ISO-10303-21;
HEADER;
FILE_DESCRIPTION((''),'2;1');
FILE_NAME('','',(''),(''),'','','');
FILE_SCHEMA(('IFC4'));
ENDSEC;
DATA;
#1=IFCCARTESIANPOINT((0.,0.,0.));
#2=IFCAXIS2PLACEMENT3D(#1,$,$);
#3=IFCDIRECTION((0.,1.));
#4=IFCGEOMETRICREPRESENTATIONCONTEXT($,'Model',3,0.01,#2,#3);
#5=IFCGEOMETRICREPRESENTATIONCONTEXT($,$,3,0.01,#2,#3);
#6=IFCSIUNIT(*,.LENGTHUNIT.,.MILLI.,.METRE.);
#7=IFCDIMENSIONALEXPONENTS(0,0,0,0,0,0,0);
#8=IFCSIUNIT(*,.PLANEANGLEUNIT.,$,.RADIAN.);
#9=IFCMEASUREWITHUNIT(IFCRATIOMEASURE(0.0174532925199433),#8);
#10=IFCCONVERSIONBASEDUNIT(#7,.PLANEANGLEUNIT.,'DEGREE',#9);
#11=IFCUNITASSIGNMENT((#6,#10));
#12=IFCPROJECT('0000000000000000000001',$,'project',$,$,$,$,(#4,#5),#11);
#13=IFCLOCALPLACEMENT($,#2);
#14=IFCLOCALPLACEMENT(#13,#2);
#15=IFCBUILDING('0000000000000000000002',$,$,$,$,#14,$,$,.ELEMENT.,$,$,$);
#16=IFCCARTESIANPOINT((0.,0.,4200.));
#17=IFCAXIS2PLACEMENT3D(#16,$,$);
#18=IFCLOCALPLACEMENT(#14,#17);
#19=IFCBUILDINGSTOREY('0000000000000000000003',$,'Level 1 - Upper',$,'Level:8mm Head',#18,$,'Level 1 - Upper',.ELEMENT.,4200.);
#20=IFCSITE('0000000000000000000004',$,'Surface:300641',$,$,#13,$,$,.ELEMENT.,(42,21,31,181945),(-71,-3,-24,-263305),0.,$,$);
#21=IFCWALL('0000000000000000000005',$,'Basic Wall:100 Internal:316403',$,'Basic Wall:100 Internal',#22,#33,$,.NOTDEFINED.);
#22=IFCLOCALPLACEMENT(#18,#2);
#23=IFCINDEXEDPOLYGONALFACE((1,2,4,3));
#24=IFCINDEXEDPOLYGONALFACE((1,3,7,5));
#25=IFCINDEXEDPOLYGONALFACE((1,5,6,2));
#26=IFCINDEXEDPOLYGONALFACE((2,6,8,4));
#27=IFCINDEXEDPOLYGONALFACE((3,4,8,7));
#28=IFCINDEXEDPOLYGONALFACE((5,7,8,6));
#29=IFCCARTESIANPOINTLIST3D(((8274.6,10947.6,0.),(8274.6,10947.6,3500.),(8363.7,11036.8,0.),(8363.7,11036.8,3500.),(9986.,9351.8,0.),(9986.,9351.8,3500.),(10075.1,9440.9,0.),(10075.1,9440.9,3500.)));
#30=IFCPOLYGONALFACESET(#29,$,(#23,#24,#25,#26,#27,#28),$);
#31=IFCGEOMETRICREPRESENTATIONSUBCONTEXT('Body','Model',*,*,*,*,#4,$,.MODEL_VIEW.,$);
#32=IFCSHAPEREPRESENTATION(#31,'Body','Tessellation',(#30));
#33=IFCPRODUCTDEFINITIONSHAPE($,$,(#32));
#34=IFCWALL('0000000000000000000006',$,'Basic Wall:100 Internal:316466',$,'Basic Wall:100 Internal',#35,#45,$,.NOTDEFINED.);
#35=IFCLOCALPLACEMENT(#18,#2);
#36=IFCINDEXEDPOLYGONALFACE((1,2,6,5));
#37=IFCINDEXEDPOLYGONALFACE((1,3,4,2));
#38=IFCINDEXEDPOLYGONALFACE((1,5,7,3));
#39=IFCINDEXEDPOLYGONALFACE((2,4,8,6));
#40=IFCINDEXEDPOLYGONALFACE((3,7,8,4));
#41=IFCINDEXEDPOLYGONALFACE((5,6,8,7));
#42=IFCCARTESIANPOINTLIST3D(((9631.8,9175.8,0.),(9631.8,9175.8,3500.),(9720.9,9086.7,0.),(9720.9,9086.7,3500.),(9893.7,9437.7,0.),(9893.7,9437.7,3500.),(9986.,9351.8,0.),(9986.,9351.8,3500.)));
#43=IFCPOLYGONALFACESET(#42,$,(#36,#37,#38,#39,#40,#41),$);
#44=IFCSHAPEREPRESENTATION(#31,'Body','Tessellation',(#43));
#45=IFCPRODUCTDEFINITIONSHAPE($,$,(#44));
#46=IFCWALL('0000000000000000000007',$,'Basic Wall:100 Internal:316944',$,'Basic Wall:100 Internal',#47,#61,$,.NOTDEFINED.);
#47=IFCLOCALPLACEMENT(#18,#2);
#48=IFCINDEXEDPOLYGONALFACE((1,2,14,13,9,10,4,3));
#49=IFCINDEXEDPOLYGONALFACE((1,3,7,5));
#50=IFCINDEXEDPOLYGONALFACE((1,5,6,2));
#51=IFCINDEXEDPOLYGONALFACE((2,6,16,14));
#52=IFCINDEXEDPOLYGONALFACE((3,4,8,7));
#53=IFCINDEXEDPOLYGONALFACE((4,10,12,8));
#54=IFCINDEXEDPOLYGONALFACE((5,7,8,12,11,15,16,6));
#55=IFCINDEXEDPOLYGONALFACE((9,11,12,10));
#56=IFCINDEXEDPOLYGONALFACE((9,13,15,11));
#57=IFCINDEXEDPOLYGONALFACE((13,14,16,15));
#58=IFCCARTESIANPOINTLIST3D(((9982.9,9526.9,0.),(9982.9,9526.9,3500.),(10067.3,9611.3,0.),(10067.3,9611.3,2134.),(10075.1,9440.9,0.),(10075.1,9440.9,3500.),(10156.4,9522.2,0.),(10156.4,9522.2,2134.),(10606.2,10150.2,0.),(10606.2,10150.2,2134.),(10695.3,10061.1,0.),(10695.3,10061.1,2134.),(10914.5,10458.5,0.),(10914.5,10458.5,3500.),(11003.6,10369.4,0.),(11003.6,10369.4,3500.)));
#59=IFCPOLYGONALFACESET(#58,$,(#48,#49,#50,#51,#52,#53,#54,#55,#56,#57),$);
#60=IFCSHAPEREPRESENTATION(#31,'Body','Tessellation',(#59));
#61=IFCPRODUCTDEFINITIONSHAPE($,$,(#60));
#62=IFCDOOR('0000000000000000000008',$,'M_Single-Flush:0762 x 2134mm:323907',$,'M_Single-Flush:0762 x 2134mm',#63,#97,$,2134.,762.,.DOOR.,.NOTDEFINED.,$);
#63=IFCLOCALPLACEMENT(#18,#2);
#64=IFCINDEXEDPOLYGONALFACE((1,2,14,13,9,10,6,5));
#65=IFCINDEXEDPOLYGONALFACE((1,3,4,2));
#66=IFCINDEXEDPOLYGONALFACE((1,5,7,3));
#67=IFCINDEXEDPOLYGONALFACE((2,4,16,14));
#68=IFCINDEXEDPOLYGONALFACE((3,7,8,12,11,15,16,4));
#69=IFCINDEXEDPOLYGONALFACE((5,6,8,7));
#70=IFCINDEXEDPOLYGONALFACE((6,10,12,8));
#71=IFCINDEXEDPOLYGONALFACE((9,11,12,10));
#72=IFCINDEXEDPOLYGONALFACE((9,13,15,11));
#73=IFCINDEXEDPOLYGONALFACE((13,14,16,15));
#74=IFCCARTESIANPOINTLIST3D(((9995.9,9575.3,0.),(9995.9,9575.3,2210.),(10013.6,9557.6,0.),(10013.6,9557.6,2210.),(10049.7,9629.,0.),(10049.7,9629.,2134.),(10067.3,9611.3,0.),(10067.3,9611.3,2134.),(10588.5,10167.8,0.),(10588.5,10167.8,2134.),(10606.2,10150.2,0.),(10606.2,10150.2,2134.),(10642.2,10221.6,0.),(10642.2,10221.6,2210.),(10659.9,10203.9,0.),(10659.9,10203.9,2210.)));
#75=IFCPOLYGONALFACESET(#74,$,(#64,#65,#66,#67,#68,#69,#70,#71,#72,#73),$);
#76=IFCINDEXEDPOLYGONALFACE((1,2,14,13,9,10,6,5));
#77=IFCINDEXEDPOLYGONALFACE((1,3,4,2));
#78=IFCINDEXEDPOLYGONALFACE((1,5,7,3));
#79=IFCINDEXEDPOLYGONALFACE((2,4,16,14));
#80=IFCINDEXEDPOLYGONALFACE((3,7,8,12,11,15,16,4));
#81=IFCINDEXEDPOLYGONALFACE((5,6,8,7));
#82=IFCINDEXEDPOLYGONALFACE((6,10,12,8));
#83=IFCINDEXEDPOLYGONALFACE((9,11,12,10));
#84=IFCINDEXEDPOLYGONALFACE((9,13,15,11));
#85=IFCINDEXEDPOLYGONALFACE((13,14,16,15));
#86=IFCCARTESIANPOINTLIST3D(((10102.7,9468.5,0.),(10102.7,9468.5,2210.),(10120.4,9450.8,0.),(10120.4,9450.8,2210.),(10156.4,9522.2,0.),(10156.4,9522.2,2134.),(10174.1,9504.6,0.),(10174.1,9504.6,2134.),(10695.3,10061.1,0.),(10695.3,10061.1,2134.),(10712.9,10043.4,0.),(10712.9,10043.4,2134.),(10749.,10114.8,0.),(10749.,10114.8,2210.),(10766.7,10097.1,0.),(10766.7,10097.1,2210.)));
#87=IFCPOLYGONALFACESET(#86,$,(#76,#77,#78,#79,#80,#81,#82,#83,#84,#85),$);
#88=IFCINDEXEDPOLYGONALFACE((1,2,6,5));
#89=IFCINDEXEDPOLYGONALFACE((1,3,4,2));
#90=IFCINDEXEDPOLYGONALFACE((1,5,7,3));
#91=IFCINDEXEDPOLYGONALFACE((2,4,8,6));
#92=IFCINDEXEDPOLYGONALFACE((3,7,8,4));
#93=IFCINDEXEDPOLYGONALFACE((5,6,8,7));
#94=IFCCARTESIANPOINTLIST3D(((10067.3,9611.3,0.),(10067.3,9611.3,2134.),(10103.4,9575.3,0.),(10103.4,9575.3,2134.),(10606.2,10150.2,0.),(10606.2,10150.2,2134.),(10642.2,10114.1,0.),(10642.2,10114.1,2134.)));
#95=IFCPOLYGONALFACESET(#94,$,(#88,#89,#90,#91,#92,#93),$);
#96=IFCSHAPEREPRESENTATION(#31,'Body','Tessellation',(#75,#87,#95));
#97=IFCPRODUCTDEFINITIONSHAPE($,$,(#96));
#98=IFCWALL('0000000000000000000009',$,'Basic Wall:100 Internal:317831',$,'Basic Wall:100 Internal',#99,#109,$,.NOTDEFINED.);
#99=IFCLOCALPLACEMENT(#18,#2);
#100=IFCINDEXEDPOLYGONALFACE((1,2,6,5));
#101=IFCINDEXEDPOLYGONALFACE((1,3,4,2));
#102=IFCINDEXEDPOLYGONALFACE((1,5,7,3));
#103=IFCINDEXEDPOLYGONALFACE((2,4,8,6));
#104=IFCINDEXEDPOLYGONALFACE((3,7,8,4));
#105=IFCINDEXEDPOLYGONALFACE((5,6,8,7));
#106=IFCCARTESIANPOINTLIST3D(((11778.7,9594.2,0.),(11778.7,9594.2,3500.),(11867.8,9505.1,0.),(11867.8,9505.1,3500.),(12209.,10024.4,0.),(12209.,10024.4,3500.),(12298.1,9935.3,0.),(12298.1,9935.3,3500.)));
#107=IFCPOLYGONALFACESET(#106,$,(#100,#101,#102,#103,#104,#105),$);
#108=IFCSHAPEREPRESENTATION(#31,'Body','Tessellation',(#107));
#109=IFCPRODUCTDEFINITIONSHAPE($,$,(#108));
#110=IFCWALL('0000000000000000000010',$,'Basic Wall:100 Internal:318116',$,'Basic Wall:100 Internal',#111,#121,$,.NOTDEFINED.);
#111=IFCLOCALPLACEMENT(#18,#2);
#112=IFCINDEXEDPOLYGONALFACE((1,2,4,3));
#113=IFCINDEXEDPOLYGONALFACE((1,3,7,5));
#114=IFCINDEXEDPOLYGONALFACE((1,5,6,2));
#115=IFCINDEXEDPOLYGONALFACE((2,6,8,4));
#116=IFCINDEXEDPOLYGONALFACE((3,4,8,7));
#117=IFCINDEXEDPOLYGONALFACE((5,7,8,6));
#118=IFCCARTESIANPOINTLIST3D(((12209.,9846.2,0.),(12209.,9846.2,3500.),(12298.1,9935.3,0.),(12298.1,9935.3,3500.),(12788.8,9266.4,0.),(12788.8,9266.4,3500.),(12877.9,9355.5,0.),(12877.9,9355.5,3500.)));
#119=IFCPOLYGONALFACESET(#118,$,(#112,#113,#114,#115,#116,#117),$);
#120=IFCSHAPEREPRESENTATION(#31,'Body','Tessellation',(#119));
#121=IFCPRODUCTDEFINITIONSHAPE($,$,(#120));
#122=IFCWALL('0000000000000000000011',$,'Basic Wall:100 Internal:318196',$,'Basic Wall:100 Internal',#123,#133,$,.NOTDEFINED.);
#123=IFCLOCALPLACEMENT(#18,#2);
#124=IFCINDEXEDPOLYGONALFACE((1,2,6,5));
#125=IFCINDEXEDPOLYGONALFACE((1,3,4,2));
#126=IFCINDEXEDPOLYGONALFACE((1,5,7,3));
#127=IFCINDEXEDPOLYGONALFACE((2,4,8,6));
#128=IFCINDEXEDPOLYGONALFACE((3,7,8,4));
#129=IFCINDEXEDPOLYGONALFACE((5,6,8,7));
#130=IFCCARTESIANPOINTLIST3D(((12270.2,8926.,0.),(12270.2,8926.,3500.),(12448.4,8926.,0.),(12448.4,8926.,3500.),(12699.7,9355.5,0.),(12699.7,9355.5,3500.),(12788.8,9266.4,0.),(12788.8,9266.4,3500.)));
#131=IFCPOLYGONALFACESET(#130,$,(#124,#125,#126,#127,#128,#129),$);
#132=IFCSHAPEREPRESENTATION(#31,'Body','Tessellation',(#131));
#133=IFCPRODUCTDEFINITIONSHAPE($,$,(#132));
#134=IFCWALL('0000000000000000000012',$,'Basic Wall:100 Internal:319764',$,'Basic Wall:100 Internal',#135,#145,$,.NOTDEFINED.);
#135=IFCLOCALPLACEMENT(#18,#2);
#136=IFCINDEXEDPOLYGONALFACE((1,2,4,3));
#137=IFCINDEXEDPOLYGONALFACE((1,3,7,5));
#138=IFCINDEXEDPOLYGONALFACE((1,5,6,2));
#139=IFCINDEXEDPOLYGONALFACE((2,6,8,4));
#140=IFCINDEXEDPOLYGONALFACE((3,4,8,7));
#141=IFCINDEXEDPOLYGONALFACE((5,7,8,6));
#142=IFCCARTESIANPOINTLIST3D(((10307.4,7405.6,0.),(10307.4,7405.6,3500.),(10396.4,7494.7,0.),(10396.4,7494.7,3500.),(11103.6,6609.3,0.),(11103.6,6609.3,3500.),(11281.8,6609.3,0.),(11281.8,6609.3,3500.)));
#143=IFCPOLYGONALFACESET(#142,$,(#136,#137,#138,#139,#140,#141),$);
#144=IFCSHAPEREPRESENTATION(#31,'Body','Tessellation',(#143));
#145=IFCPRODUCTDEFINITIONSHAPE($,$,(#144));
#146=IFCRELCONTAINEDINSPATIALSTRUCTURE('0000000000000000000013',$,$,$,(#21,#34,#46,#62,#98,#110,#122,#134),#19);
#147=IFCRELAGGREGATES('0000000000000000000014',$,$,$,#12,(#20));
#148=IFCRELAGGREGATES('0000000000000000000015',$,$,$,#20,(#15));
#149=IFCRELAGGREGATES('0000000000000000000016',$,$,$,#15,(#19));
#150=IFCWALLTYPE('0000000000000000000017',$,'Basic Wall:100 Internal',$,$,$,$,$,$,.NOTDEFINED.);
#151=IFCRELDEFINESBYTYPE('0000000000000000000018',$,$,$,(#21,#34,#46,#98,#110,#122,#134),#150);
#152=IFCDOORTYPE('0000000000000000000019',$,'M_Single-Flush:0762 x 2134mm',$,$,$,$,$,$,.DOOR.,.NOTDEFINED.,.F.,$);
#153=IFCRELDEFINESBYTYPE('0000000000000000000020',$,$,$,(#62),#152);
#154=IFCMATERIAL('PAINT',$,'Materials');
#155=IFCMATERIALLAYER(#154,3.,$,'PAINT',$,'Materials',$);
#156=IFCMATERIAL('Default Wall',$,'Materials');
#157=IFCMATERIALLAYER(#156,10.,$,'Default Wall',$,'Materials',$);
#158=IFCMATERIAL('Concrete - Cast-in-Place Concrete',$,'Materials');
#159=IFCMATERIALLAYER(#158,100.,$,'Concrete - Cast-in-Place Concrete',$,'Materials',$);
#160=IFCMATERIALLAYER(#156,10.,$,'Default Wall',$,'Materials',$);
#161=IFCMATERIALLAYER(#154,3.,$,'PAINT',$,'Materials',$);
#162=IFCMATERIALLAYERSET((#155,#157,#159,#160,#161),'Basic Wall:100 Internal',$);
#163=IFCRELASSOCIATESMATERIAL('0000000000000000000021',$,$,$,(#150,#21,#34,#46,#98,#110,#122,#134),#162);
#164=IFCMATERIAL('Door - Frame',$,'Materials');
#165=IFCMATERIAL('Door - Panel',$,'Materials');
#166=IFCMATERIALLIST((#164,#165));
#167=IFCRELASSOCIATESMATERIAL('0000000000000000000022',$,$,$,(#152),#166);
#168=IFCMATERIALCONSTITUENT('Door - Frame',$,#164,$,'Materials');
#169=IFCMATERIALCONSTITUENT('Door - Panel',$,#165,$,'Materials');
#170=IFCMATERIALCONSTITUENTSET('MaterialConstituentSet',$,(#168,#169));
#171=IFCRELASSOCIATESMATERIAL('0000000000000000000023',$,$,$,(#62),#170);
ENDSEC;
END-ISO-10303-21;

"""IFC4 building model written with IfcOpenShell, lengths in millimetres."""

from ifc_helpers import new_model, entity, si_unit, converted_unit, direction, frame, frame_2d, origin, place, context, subcontext, project, spatial, polyline, rectangle, outline, extrude, clip, halfspace, source, transform, mapped, material, material_list, layer, layer_set, layer_usage, constituent, constituent_set, type_object, type_shapes, element, fill, save


model = new_model("IFC4")

# Units and contexts
model_context = context("Model", 3, precision=0.01, world=origin(), true_north=direction((0.0, 1.0)))
context_of_model = context(None, 3, precision=0.01, world=origin(), true_north=direction((0.0, 1.0)))
body_context = subcontext(model_context, "Body", "Model", "MODEL_VIEW")
ifc_project = project(units=[si_unit("LENGTHUNIT", "METRE", prefix="MILLI"), converted_unit("PLANEANGLEUNIT", "DEGREE", entity("IfcRatioMeasure", 0.0174532925199433), si_unit("PLANEANGLEUNIT", "RADIAN"), dimensions=[0, 0, 0, 0, 0, 0, 0])], contexts=[model_context, context_of_model])

# Site, building, storey
site_placement = place(None, origin())
site = spatial("IfcSite", under=ifc_project, at=site_placement, Name="Surface:300641", CompositionType="ELEMENT", RefLatitude=(42, 21, 31, 181945), RefLongitude=(-71, -3, -24, -263305), RefElevation=0.0)
building_placement = place(site_placement, origin())
building = spatial("IfcBuilding", under=site, at=building_placement, CompositionType="ELEMENT")
storey_placement = place(building_placement, frame((0.0, 0.0, 4200.0)))
storey = spatial("IfcBuildingStorey", under=building, at=storey_placement, Name="Level 1 - Upper", ObjectType="Level:8mm Head", LongName="Level 1 - Upper", CompositionType="ELEMENT", Elevation=4200.0)

# Shared definitions
ifc_material_1 = material(Name="PAINT", Category="Materials")
ifc_material_2 = material(Name="Concrete - Cast-in-Place Concrete", Category="Materials")
ifc_material_3 = material(Name="Default Wall", Category="Materials")

# Shared definitions
ifc_layer_1 = layer(ifc_material_1, 3.0, Name="PAINT", Category="Materials")
ifc_layer_2 = layer(ifc_material_3, 10.0, Name="Default Wall", Category="Materials")
ifc_layer_3 = layer(ifc_material_2, 100.0, Name="Concrete - Cast-in-Place Concrete", Category="Materials")
ifc_layer_4 = layer(ifc_material_3, 10.0, Name="Default Wall", Category="Materials")
ifc_layer_5 = layer(ifc_material_1, 3.0, Name="PAINT", Category="Materials")
ifc_layer_set_1 = layer_set([ifc_layer_1, ifc_layer_2, ifc_layer_3, ifc_layer_4, ifc_layer_5], Name="Basic Wall:100 Internal")
wall_type_1 = type_object("IfcWallType", Name="Basic Wall:100 Internal", PredefinedType="NOTDEFINED", material=ifc_layer_set_1)

# Shared definitions
ifc_material_4 = material(Name="Door - Frame", Category="Materials")
ifc_material_5 = material(Name="Door - Panel", Category="Materials")
ifc_material_list = material_list([ifc_material_4, ifc_material_5])
door_type = type_object("IfcDoorType", Name="M_Single-Flush:0762 x 2134mm", OperationType="NOTDEFINED", ParameterTakesPrecedence=False, PredefinedType="DOOR", material=ifc_material_list)
shared_shape_1 = source(origin(), body_context, "Body", "SweptSolid", [
    extrude(outline(polyline([(-457.0, -1124.0), (457.0, -1124.0), (457.0, 1086.0), (381.0, 1086.0), (381.0, -1048.0), (-381.0, -1048.0), (-381.0, 1086.0), (-457.0, 1086.0), (-457.0, -1124.0)])), frame((381.0, 151.0, 1086.0), z_axis=(0.0, -1.0, 0.0), x_axis=(-1.0, 0.0, 0.0)), (0.0, 0.0, 1.0), 25.0),
    extrude(outline(polyline([(-1124.0, -457.0), (1086.0, -457.0), (1086.0, -381.0), (-1048.0, -381.0), (-1048.0, 381.0), (1086.0, 381.0), (1086.0, 457.0), (-1124.0, 457.0), (-1124.0, -457.0)])), frame((381.0, 0.0, 1086.0), z_axis=(0.0, -1.0, 0.0), x_axis=(0.0, 0.0, -1.0)), (0.0, 0.0, 1.0), 25.0),
    extrude(rectangle(XDim=762.0, YDim=51.0, at=frame_2d((0.0, 0.0), x_axis=(1.0, 0.0))), frame((381.0, 100.5, 0.0)), (0.0, 0.0, 1.0), 2134.0),
])
type_shapes(door_type, [shared_shape_1])

# Walls
ifc_layer_usage_1 = layer_usage(ifc_layer_set_1, "AXIS2", "NEGATIVE", 63.0)
wall_1_placement = place(storey_placement, frame((8317.6, 10993.7, 0.0), z_axis=(0.0, 0.0, 1.0), x_axis=(0.731354, -0.681998, 0.0)))
element("IfcWall", 1, at=wall_1_placement, inside=storey, type_object=wall_type_1, material=ifc_layer_usage_1, Name="Basic Wall:100 Internal:316403", ObjectType="Basic Wall:100 Internal", PredefinedType="NOTDEFINED", context=body_context, shape_type="Clipping", body=[
    clip(extrude(outline(polyline([(2340.0, -63.0), (2344.4, 63.0), (2218.3, 63.0), (4.4, 63.0), (0.0, -63.0), (2213.9, -63.0), (2340.0, -63.0)])), origin(), (0.0, 0.0, 1.0), 3500.0), halfspace(origin(), True)),
])
ifc_layer_usage_2 = layer_usage(ifc_layer_set_1, "AXIS2", "NEGATIVE", 63.0)
wall_2_placement = place(storey_placement, frame((9941.4, 9396.3, 0.0), z_axis=(0.0, 0.0, 1.0), x_axis=(-0.707107, -0.707107, 0.0)))
element("IfcWall", 2, at=wall_2_placement, inside=storey, type_object=wall_type_1, material=ifc_layer_usage_2, Name="Basic Wall:100 Internal:316466", ObjectType="Basic Wall:100 Internal", PredefinedType="NOTDEFINED", context=body_context, shape_type="Clipping", body=[
    clip(extrude(outline(polyline([(374.9, -63.0), (374.9, 63.0), (0.0, 63.0), (4.4, -63.0), (374.9, -63.0)])), origin(), (0.0, 0.0, 1.0), 3500.0), halfspace(origin(), True)),
])

# Wall, opening, door
ifc_layer_usage_3 = layer_usage(ifc_layer_set_1, "AXIS2", "NEGATIVE", 63.0)
wall_3_placement = place(storey_placement, frame((10959.0, 10413.9, 0.0), z_axis=(0.0, 0.0, 1.0), x_axis=(-0.707107, -0.707107, 0.0)))
wall_3 = element("IfcWall", 3, at=wall_3_placement, inside=storey, type_object=wall_type_1, material=ifc_layer_usage_3, Name="Basic Wall:100 Internal:316944", ObjectType="Basic Wall:100 Internal", PredefinedType="NOTDEFINED", context=body_context, shape_type="Clipping", body=[
    clip(extrude(outline(polyline([(0.0, -63.0), (254.0, -63.0), (380.0, -63.0), (1317.4, -63.0), (1313.0, 63.0), (0.0, 63.0), (0.0, -63.0)])), origin(), (0.0, 0.0, 1.0), 3500.0), halfspace(origin(), True)),
])
opening_1_placement = place(wall_3_placement, frame((1198.0, 63.0, 0.0)))
opening_1 = element("IfcOpeningElement", 4, at=opening_1_placement, cuts=wall_3, ObjectType="Opening", PredefinedType="OPENING", context=body_context, shape_type="SweptSolid", body=[
    extrude(rectangle(XDim=762.0, YDim=2134.0, at=frame_2d((1067.0, 381.0), x_axis=(0.0, -1.0))), frame((0.0, 0.0, 0.0), z_axis=(0.0, -1.0, 0.0), x_axis=(0.0, 0.0, 1.0)), (0.0, 0.0, 1.0), 126.0),
])
ifc_constituent_1 = constituent(ifc_material_4, Name="Door - Frame", Category="Materials")
ifc_constituent_2 = constituent(ifc_material_5, Name="Door - Panel", Category="Materials")
ifc_constituent_set_1 = constituent_set(constituents=[ifc_constituent_1, ifc_constituent_2], Name="MaterialConstituentSet")
door_1_placement = place(opening_1_placement, frame((0.0, 0.0, 0.0), z_axis=(0.0, 0.0, 1.0), x_axis=(-1.0, 0.0, 0.0)))
door_1 = element("IfcDoor", 5, at=door_1_placement, inside=storey, type_object=door_type, material=ifc_constituent_set_1, Name="M_Single-Flush:0762 x 2134mm:323907", ObjectType="M_Single-Flush:0762 x 2134mm", OperationType="NOTDEFINED", OverallHeight=2134.0, OverallWidth=762.0, PredefinedType="DOOR", context=body_context, shape_type="MappedRepresentation", body=[
    mapped(shared_shape_1, transform((0.0, 0.0, 0.0), scale=1.0)),
])
fill(opening_1, door_1)

# Walls
ifc_layer_usage_4 = layer_usage(ifc_layer_set_1, "AXIS2", "NEGATIVE", 63.0)
wall_4_placement = place(storey_placement, frame((11823.3, 9549.6, 0.0), z_axis=(0.0, 0.0, 1.0), x_axis=(0.707107, 0.707107, 0.0)))
element("IfcWall", 6, at=wall_4_placement, inside=storey, type_object=wall_type_1, material=ifc_layer_usage_4, Name="Basic Wall:100 Internal:317831", ObjectType="Basic Wall:100 Internal", PredefinedType="NOTDEFINED", context=body_context, shape_type="Clipping", body=[
    clip(extrude(rectangle(XDim=608.4, YDim=126.0, at=frame_2d((304.2, 0.0), x_axis=(-1.0, 0.0))), origin(), (0.0, 0.0, 1.0), 3500.0), halfspace(origin(), True)),
])
ifc_layer_usage_5 = layer_usage(ifc_layer_set_1, "AXIS2", "NEGATIVE", 63.0)
wall_5_placement = place(storey_placement, frame((12253.5, 9890.7, 0.0), z_axis=(0.0, 0.0, 1.0), x_axis=(0.707107, -0.707107, 0.0)))
element("IfcWall", 7, at=wall_5_placement, inside=storey, type_object=wall_type_1, material=ifc_layer_usage_5, Name="Basic Wall:100 Internal:318116", ObjectType="Basic Wall:100 Internal", PredefinedType="NOTDEFINED", context=body_context, shape_type="Clipping", body=[
    clip(extrude(rectangle(XDim=820.0, YDim=126.0, at=frame_2d((410.0, 0.0), x_axis=(-1.0, 0.0))), origin(), (0.0, 0.0, 1.0), 3500.0), halfspace(origin(), True)),
])
ifc_layer_usage_6 = layer_usage(ifc_layer_set_1, "AXIS2", "NEGATIVE", 63.0)
wall_6_placement = place(storey_placement, frame((12744.2, 9310.9, 0.0), z_axis=(0.0, 0.0, 1.0), x_axis=(-0.707107, -0.707107, 0.0)))
element("IfcWall", 8, at=wall_6_placement, inside=storey, type_object=wall_type_1, material=ifc_layer_usage_6, Name="Basic Wall:100 Internal:318196", ObjectType="Basic Wall:100 Internal", PredefinedType="NOTDEFINED", context=body_context, shape_type="Clipping", body=[
    clip(extrude(outline(polyline([(607.4, -63.0), (545.3, -0.9), (481.4, 63.0), (0.0, 63.0), (0.0, -63.0), (607.4, -63.0)])), origin(), (0.0, 0.0, 1.0), 3500.0), halfspace(origin(), True)),
])
ifc_layer_usage_7 = layer_usage(ifc_layer_set_1, "AXIS2", "NEGATIVE", 63.0)
wall_7_placement = place(storey_placement, frame((10351.9, 7450.1, 0.0), z_axis=(0.0, 0.0, 1.0), x_axis=(0.707107, -0.707107, 0.0)))
element("IfcWall", 9, at=wall_7_placement, inside=storey, type_object=wall_type_1, material=ifc_layer_usage_7, Name="Basic Wall:100 Internal:319764", ObjectType="Basic Wall:100 Internal", PredefinedType="NOTDEFINED", context=body_context, shape_type="Clipping", body=[
    clip(extrude(outline(polyline([(1126.1, -63.0), (1252.1, 63.0), (1073.9, 63.0), (0.0, 63.0), (0.0, -63.0), (1126.1, -63.0)])), origin(), (0.0, 0.0, 1.0), 3500.0), halfspace(origin(), True)),
])

save(model, "model.ifc")
